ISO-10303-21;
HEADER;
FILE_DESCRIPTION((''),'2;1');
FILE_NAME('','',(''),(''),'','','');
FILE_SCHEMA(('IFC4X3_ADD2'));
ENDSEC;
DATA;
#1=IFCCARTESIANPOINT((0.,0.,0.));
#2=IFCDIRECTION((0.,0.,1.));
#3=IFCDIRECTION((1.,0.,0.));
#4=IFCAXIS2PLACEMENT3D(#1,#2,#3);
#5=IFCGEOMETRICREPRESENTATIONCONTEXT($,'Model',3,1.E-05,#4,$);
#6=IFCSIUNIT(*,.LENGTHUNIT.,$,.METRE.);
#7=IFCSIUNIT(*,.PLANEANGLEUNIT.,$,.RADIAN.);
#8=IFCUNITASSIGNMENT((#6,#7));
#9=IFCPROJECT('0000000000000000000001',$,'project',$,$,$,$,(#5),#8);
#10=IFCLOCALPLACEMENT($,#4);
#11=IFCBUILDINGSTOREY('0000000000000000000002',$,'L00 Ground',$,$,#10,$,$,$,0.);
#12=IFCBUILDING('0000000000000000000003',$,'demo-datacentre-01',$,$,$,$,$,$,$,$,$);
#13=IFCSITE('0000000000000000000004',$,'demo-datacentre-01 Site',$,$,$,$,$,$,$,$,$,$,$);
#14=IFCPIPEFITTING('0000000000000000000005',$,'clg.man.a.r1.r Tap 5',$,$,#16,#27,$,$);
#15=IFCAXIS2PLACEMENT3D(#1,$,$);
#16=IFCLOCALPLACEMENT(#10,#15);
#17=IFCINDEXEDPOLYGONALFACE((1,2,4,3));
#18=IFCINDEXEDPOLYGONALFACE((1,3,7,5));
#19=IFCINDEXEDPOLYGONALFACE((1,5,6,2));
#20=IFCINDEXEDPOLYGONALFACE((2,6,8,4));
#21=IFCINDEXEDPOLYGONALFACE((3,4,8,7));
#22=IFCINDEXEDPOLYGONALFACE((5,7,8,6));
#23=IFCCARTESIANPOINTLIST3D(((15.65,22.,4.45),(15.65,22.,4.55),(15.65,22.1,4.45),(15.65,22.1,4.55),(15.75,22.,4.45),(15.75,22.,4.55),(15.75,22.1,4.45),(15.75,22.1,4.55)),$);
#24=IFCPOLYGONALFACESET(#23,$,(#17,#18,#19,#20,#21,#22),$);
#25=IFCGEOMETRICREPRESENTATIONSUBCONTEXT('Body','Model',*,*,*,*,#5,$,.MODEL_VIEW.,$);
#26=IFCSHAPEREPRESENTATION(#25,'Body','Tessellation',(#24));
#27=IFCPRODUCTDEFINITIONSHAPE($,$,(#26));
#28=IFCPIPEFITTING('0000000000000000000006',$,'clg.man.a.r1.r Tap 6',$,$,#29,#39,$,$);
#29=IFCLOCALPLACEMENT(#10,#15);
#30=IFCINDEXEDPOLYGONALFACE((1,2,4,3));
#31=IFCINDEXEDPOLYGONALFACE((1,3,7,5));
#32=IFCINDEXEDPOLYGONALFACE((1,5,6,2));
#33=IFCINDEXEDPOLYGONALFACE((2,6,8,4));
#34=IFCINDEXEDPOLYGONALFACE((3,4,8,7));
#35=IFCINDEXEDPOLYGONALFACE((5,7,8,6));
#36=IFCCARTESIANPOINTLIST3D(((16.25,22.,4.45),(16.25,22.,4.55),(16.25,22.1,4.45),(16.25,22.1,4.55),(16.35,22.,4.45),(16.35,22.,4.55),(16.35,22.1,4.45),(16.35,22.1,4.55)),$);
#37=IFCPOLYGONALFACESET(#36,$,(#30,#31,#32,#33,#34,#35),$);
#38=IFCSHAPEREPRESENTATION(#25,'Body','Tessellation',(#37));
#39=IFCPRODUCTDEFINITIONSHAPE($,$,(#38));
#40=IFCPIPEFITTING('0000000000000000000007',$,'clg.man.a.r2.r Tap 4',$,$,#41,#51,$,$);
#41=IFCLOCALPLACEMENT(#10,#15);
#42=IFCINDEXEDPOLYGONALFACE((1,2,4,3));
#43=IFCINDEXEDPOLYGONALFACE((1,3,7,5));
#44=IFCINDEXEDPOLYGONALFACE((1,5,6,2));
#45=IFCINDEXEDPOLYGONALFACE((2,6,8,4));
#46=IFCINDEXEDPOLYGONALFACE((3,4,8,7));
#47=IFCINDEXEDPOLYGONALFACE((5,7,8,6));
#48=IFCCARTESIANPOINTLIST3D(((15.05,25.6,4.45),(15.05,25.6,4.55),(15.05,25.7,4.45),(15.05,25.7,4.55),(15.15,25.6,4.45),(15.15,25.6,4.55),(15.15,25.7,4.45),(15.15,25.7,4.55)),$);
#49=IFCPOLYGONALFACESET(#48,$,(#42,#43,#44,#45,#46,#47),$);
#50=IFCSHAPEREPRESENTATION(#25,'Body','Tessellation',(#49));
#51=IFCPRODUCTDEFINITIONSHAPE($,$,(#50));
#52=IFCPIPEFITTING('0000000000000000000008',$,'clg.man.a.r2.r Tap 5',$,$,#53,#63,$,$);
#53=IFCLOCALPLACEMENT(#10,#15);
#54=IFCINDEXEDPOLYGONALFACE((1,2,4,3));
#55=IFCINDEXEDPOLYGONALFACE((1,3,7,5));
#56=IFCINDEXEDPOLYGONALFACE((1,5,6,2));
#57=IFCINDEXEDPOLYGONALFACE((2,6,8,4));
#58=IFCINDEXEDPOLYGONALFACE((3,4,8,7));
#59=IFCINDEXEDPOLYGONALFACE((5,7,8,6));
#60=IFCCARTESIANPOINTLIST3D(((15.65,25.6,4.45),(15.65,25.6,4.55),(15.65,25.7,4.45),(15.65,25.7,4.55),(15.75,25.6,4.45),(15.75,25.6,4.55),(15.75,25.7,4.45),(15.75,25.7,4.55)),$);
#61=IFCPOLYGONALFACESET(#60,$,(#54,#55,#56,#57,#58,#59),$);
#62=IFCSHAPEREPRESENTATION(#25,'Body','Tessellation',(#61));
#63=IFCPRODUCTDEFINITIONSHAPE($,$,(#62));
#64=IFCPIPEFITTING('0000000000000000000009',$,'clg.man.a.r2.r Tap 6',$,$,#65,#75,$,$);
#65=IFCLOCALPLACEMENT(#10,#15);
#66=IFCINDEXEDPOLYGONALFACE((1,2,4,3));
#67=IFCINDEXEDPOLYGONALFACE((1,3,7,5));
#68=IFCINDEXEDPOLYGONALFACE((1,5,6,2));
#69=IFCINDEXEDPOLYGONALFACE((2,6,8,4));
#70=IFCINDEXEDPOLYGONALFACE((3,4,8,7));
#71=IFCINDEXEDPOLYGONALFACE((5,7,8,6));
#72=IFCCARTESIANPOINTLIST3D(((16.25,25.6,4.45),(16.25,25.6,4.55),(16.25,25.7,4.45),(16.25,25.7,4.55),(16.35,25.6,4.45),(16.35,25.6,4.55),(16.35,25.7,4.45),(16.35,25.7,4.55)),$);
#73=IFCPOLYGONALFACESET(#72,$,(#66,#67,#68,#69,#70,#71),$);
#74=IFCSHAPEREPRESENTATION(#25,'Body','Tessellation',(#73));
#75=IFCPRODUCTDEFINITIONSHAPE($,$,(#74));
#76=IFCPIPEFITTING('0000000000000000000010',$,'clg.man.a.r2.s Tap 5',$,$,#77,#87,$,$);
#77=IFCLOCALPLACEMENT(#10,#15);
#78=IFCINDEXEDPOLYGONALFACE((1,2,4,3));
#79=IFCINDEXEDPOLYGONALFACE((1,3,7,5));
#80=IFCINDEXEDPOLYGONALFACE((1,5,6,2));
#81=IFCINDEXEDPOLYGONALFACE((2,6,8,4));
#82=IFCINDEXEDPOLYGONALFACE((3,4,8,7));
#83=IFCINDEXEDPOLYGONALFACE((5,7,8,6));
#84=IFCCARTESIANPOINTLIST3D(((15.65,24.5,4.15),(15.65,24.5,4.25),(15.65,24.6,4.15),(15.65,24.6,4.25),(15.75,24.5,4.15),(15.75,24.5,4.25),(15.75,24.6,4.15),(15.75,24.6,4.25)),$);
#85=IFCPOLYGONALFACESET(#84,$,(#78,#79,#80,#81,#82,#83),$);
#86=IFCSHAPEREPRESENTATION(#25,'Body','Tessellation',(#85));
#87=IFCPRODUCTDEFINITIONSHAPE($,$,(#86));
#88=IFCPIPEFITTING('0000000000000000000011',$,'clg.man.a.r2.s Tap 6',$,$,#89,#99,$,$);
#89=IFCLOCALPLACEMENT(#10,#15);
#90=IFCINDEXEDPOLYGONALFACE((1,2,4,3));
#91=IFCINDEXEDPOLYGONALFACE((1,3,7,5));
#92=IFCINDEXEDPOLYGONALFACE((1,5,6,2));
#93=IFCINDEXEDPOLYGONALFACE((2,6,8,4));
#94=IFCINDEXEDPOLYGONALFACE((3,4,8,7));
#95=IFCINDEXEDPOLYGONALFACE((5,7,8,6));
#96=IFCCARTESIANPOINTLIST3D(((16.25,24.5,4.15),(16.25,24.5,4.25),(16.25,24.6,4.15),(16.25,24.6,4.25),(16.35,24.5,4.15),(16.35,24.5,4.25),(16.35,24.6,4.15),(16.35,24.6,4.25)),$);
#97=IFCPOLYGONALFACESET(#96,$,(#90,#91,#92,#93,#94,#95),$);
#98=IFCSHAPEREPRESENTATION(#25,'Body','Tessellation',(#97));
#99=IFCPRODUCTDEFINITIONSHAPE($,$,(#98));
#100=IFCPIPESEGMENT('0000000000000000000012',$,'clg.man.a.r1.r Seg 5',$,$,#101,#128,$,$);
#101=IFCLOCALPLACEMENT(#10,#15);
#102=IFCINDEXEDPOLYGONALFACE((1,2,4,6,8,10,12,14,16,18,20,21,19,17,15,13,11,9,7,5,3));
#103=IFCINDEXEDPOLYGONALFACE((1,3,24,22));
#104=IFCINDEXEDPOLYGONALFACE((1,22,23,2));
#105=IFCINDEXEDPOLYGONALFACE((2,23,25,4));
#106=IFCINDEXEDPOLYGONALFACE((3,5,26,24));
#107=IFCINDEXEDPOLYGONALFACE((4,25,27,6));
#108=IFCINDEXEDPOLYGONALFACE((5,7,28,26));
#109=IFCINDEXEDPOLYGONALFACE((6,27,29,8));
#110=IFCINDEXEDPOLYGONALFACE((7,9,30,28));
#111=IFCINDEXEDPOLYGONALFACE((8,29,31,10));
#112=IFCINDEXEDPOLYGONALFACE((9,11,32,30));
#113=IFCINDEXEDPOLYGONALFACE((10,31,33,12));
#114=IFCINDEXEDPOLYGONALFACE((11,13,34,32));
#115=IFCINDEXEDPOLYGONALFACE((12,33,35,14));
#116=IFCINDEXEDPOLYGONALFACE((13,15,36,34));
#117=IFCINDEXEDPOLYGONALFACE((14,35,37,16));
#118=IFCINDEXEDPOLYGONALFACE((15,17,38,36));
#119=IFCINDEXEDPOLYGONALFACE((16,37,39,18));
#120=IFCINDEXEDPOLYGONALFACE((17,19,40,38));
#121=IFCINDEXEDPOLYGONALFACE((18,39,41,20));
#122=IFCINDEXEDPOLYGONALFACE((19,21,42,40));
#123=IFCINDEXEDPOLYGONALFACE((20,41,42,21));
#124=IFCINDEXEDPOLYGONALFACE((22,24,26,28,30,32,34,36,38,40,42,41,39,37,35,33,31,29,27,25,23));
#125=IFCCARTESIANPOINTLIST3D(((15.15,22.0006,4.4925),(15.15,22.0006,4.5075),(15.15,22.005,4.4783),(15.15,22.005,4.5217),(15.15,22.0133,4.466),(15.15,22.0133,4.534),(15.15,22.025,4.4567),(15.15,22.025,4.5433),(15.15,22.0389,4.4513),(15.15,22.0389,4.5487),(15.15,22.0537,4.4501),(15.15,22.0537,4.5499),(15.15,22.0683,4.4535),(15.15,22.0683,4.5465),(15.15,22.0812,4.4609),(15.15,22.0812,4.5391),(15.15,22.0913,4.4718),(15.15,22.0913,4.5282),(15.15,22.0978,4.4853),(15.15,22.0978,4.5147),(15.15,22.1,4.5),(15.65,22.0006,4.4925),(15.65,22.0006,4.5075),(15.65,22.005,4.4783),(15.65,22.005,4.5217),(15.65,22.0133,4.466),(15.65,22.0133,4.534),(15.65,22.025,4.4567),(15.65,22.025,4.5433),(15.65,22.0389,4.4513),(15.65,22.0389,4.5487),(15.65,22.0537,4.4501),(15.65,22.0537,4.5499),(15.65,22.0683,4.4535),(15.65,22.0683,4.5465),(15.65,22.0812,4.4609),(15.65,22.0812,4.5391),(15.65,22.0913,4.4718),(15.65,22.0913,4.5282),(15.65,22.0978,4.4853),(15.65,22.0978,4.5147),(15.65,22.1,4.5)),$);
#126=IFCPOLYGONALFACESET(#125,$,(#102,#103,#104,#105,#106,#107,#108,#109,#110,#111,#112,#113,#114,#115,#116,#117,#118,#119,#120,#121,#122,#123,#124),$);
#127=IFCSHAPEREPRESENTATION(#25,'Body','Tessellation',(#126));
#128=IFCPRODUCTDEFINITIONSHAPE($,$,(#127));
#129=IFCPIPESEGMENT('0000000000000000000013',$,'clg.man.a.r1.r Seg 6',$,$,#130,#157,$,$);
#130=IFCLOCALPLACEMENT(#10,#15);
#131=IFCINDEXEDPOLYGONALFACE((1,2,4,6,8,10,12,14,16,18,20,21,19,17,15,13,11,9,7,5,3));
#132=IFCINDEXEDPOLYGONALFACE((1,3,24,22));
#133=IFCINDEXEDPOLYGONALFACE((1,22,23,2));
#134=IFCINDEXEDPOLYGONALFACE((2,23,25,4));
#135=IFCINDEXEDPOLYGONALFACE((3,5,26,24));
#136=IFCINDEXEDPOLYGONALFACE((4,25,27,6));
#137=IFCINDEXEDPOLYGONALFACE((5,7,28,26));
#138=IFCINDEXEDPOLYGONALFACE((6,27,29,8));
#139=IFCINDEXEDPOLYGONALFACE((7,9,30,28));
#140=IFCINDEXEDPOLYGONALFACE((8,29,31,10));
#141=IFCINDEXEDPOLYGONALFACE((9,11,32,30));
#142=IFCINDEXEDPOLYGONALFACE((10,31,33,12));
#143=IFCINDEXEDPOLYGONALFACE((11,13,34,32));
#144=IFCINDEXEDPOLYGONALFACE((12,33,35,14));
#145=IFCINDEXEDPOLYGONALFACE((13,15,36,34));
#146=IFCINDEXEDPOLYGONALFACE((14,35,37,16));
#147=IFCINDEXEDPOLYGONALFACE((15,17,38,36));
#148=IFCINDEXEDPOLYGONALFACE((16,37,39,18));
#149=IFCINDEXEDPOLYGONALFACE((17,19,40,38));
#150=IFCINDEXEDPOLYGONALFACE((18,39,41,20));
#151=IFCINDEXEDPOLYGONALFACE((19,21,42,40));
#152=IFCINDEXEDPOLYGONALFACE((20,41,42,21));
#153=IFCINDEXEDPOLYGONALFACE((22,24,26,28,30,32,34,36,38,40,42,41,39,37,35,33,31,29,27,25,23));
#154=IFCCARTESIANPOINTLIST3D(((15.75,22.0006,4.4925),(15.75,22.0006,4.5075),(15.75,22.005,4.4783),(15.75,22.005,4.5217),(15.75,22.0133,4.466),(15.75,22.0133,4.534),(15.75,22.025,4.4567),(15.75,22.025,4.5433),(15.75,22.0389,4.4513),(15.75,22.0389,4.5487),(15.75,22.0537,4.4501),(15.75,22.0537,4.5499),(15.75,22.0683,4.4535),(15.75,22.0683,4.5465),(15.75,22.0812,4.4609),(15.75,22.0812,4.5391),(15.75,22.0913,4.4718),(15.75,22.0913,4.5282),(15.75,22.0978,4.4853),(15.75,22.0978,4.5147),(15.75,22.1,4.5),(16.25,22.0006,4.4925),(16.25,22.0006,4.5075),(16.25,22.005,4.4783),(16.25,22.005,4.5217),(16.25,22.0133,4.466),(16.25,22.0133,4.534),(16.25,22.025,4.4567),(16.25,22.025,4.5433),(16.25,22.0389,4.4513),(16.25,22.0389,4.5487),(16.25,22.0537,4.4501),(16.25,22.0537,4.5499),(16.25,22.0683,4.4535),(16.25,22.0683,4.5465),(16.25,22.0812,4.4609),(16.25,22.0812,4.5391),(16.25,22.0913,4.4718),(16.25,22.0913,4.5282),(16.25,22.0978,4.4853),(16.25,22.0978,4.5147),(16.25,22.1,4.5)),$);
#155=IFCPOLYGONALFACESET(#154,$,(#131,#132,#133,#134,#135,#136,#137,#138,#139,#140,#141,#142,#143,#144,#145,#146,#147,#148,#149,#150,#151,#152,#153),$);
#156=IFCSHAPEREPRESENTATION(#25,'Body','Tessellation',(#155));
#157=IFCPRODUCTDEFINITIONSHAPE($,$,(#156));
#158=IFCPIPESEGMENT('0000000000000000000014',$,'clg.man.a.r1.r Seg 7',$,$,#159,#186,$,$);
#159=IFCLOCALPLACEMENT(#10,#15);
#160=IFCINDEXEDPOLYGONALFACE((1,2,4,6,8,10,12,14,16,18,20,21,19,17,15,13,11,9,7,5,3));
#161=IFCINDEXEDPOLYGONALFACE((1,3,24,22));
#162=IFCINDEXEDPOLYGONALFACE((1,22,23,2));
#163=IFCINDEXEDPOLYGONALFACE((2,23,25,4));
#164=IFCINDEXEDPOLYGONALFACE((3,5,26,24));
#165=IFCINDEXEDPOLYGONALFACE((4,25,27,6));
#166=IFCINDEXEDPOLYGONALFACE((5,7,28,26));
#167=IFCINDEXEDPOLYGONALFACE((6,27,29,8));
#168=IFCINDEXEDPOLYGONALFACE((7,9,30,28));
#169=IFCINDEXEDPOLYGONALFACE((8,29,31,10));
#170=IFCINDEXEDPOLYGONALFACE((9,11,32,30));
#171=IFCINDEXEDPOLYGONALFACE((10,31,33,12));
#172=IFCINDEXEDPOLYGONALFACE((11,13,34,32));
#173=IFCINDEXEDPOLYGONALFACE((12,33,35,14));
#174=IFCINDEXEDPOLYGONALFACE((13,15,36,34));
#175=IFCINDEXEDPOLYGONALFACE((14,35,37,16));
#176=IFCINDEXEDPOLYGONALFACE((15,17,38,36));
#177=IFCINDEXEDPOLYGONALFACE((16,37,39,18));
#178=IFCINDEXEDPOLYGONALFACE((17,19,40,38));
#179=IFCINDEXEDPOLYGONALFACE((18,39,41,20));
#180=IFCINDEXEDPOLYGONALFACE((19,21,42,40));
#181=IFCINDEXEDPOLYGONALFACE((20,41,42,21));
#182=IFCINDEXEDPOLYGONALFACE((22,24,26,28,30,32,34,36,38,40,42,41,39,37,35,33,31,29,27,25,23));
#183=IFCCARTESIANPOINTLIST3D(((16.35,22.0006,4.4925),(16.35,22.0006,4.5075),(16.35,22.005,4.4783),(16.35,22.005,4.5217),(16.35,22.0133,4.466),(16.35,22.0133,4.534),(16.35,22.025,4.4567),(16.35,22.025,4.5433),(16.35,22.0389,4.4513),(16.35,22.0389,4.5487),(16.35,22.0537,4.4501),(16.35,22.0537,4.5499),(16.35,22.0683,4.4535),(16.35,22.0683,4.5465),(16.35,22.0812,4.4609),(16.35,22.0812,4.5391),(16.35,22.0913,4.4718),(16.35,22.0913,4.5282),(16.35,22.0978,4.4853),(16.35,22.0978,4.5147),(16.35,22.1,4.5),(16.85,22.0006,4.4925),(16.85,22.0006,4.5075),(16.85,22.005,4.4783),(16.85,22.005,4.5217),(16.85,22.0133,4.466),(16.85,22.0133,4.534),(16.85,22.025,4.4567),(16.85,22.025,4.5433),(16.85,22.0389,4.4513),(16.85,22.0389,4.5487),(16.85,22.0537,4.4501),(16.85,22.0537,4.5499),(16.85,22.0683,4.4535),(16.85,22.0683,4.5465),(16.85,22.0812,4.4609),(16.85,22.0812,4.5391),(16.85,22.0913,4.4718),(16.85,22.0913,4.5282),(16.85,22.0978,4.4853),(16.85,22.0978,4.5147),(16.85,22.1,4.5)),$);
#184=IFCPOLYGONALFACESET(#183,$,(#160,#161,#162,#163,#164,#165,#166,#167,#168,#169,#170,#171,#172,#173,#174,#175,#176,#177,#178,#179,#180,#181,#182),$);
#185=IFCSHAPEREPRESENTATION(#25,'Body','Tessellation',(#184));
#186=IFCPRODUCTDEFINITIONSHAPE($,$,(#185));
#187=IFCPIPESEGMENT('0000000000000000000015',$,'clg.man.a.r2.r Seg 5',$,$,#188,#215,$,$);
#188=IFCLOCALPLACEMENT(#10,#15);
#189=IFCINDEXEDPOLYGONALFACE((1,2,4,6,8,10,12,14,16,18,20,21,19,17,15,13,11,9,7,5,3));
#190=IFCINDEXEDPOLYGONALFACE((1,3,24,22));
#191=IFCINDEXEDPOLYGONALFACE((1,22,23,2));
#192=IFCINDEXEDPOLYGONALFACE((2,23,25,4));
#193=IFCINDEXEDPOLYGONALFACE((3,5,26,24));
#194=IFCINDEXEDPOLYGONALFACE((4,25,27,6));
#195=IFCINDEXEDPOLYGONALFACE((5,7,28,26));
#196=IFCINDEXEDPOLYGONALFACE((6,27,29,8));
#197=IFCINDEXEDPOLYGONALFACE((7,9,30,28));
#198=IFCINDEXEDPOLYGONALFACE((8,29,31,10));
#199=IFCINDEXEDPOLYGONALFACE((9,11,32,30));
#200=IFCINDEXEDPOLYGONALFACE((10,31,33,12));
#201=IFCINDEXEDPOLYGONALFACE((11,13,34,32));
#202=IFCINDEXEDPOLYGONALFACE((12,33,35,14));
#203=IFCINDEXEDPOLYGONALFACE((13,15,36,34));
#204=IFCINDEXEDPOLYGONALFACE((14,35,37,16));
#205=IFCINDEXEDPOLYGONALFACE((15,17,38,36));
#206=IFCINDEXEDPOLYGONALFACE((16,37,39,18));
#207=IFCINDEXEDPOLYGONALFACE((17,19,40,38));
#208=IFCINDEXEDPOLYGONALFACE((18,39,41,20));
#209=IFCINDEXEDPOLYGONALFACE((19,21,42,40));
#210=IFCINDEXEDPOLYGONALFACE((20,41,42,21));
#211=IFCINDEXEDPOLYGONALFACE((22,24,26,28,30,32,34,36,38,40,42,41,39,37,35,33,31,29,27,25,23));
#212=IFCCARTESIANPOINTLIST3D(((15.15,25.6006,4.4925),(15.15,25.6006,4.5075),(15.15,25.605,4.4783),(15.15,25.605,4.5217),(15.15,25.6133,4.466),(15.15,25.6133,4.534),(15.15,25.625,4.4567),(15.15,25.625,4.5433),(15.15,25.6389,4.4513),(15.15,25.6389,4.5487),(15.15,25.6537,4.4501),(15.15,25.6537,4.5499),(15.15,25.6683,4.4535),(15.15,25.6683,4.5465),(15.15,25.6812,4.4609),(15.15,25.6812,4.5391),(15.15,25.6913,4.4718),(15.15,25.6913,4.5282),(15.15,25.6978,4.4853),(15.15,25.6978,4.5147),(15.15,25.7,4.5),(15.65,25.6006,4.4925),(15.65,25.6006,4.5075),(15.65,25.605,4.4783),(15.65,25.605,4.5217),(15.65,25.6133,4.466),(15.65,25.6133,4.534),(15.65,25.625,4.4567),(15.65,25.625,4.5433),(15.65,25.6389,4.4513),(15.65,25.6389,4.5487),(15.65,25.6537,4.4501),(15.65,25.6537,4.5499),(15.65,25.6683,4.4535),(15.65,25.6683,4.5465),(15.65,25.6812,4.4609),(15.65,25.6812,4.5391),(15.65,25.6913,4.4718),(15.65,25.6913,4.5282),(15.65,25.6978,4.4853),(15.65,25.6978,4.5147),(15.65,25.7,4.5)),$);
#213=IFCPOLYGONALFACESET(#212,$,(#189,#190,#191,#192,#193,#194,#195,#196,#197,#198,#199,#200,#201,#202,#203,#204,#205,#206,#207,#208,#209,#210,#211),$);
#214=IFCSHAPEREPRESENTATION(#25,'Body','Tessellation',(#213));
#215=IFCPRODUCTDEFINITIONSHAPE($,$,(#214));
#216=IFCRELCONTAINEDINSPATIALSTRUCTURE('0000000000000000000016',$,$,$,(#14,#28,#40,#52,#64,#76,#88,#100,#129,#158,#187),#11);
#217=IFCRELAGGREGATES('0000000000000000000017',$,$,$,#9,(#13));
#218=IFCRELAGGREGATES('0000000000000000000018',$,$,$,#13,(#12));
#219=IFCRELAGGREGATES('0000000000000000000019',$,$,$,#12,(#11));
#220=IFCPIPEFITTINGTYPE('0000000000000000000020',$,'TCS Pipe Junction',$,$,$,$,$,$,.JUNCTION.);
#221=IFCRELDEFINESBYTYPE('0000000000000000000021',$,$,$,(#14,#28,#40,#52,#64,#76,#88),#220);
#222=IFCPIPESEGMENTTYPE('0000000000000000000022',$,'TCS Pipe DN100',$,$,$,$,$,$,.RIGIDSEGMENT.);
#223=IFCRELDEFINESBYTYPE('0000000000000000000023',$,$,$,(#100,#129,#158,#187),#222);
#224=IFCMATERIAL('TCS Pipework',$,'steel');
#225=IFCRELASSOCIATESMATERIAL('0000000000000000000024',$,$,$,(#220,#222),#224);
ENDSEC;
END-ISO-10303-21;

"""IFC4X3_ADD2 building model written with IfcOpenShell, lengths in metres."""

from ifc_helpers import new_model, si_unit, frame, origin_with_axes, place, context, subcontext, project, spatial, rectangle, circle, extrude, material, type_object, element, save


model = new_model("IFC4X3_ADD2")

# Units and contexts
model_context = context("Model", 3, precision=1e-05, world=origin_with_axes())
body_context = subcontext(model_context, "Body", "Model", "MODEL_VIEW")
ifc_project = project(units=[si_unit("LENGTHUNIT", "METRE"), si_unit("PLANEANGLEUNIT", "RADIAN")], contexts=[model_context])

# Site, building, storey
site = spatial("IfcSite", under=ifc_project, Name="demo-datacentre-01 Site")
building = spatial("IfcBuilding", under=site, Name="demo-datacentre-01")
storey_placement = place(None, origin_with_axes())
storey = spatial("IfcBuildingStorey", under=building, at=storey_placement, Name="L00 Ground", Elevation=0.0)

# Pipe fittings
ifc_material = material(Name="TCS Pipework", Category="steel")
pipe_fitting_type = type_object("IfcPipeFittingType", Name="TCS Pipe Junction", PredefinedType="JUNCTION", material=ifc_material)
for number, where, z_axis, x_axis, name in (
    (1, (15.7, 22.05, 4.45), (0.0, 0.0, 1.0), (1.0, 0.0, 0.0), "clg.man.a.r1.r Tap 5"),
    (2, (16.3, 22.05, 4.45), (0.0, 0.0, 1.0), (1.0, 0.0, 0.0), "clg.man.a.r1.r Tap 6"),
    (3, (15.1, 25.65, 4.45), (0.0, 0.0, 1.0), (1.0, 0.0, 0.0), "clg.man.a.r2.r Tap 4"),
    (4, (15.7, 25.65, 4.45), (0.0, 0.0, 1.0), (1.0, 0.0, 0.0), "clg.man.a.r2.r Tap 5"),
    (5, (16.3, 25.65, 4.45), (0.0, 0.0, 1.0), (1.0, 0.0, 0.0), "clg.man.a.r2.r Tap 6"),
    (6, (15.7, 24.55, 4.15), (0.0, 0.0, 1.0), (1.0, 0.0, 0.0), "clg.man.a.r2.s Tap 5"),
    (7, (16.3, 24.55, 4.15), (0.0, 0.0, 1.0), (1.0, 0.0, 0.0), "clg.man.a.r2.s Tap 6"),
):
    element("IfcPipeFitting", number, at=place(storey_placement, frame(where, z_axis=z_axis, x_axis=x_axis)), inside=storey, type_object=pipe_fitting_type, Name=name, context=body_context, shape_type="SweptSolid", body=[
        extrude(rectangle(XDim=0.1, YDim=0.1), origin_with_axes(), (0.0, 0.0, 1.0), 0.1),
    ])

# Pipe segments
pipe_segment_type_1 = type_object("IfcPipeSegmentType", Name="TCS Pipe DN100", PredefinedType="RIGIDSEGMENT", material=ifc_material)
for number, where, z_axis, x_axis, name in (
    (8, (15.15, 22.05, 4.5), (1.0, 0.0, 0.0), (0.0, 1.0, 0.0), "clg.man.a.r1.r Seg 5"),
    (9, (15.75, 22.05, 4.5), (1.0, 0.0, 0.0), (0.0, 1.0, 0.0), "clg.man.a.r1.r Seg 6"),
):
    element("IfcPipeSegment", number, at=place(storey_placement, frame(where, z_axis=z_axis, x_axis=x_axis)), inside=storey, type_object=pipe_segment_type_1, Name=name, context=body_context, shape_type="SweptSolid", body=[
        extrude(circle(Radius=0.05), origin_with_axes(), (0.0, 0.0, 1.0), 0.5),
    ])
pipe_segment_1_placement = place(storey_placement, frame((16.35, 22.05, 4.5), z_axis=(1.0, 0.0, 0.0), x_axis=(0.0, 1.0, 0.0)))
element("IfcPipeSegment", 10, at=pipe_segment_1_placement, inside=storey, type_object=pipe_segment_type_1, Name="clg.man.a.r1.r Seg 7", context=body_context, shape_type="SweptSolid", body=[
    extrude(circle(Radius=0.05), origin_with_axes(), (0.0, 0.0, 1.0), 0.5),
])
for number, where, z_axis, x_axis, name in (
    (11, (15.15, 25.65, 4.5), (1.0, 0.0, 0.0), (0.0, 1.0, 0.0), "clg.man.a.r2.r Seg 5"),
):
    element("IfcPipeSegment", number, at=place(storey_placement, frame(where, z_axis=z_axis, x_axis=x_axis)), inside=storey, type_object=pipe_segment_type_1, Name=name, context=body_context, shape_type="SweptSolid", body=[
        extrude(circle(Radius=0.05), origin_with_axes(), (0.0, 0.0, 1.0), 0.5),
    ])

save(model, "model.ifc")
